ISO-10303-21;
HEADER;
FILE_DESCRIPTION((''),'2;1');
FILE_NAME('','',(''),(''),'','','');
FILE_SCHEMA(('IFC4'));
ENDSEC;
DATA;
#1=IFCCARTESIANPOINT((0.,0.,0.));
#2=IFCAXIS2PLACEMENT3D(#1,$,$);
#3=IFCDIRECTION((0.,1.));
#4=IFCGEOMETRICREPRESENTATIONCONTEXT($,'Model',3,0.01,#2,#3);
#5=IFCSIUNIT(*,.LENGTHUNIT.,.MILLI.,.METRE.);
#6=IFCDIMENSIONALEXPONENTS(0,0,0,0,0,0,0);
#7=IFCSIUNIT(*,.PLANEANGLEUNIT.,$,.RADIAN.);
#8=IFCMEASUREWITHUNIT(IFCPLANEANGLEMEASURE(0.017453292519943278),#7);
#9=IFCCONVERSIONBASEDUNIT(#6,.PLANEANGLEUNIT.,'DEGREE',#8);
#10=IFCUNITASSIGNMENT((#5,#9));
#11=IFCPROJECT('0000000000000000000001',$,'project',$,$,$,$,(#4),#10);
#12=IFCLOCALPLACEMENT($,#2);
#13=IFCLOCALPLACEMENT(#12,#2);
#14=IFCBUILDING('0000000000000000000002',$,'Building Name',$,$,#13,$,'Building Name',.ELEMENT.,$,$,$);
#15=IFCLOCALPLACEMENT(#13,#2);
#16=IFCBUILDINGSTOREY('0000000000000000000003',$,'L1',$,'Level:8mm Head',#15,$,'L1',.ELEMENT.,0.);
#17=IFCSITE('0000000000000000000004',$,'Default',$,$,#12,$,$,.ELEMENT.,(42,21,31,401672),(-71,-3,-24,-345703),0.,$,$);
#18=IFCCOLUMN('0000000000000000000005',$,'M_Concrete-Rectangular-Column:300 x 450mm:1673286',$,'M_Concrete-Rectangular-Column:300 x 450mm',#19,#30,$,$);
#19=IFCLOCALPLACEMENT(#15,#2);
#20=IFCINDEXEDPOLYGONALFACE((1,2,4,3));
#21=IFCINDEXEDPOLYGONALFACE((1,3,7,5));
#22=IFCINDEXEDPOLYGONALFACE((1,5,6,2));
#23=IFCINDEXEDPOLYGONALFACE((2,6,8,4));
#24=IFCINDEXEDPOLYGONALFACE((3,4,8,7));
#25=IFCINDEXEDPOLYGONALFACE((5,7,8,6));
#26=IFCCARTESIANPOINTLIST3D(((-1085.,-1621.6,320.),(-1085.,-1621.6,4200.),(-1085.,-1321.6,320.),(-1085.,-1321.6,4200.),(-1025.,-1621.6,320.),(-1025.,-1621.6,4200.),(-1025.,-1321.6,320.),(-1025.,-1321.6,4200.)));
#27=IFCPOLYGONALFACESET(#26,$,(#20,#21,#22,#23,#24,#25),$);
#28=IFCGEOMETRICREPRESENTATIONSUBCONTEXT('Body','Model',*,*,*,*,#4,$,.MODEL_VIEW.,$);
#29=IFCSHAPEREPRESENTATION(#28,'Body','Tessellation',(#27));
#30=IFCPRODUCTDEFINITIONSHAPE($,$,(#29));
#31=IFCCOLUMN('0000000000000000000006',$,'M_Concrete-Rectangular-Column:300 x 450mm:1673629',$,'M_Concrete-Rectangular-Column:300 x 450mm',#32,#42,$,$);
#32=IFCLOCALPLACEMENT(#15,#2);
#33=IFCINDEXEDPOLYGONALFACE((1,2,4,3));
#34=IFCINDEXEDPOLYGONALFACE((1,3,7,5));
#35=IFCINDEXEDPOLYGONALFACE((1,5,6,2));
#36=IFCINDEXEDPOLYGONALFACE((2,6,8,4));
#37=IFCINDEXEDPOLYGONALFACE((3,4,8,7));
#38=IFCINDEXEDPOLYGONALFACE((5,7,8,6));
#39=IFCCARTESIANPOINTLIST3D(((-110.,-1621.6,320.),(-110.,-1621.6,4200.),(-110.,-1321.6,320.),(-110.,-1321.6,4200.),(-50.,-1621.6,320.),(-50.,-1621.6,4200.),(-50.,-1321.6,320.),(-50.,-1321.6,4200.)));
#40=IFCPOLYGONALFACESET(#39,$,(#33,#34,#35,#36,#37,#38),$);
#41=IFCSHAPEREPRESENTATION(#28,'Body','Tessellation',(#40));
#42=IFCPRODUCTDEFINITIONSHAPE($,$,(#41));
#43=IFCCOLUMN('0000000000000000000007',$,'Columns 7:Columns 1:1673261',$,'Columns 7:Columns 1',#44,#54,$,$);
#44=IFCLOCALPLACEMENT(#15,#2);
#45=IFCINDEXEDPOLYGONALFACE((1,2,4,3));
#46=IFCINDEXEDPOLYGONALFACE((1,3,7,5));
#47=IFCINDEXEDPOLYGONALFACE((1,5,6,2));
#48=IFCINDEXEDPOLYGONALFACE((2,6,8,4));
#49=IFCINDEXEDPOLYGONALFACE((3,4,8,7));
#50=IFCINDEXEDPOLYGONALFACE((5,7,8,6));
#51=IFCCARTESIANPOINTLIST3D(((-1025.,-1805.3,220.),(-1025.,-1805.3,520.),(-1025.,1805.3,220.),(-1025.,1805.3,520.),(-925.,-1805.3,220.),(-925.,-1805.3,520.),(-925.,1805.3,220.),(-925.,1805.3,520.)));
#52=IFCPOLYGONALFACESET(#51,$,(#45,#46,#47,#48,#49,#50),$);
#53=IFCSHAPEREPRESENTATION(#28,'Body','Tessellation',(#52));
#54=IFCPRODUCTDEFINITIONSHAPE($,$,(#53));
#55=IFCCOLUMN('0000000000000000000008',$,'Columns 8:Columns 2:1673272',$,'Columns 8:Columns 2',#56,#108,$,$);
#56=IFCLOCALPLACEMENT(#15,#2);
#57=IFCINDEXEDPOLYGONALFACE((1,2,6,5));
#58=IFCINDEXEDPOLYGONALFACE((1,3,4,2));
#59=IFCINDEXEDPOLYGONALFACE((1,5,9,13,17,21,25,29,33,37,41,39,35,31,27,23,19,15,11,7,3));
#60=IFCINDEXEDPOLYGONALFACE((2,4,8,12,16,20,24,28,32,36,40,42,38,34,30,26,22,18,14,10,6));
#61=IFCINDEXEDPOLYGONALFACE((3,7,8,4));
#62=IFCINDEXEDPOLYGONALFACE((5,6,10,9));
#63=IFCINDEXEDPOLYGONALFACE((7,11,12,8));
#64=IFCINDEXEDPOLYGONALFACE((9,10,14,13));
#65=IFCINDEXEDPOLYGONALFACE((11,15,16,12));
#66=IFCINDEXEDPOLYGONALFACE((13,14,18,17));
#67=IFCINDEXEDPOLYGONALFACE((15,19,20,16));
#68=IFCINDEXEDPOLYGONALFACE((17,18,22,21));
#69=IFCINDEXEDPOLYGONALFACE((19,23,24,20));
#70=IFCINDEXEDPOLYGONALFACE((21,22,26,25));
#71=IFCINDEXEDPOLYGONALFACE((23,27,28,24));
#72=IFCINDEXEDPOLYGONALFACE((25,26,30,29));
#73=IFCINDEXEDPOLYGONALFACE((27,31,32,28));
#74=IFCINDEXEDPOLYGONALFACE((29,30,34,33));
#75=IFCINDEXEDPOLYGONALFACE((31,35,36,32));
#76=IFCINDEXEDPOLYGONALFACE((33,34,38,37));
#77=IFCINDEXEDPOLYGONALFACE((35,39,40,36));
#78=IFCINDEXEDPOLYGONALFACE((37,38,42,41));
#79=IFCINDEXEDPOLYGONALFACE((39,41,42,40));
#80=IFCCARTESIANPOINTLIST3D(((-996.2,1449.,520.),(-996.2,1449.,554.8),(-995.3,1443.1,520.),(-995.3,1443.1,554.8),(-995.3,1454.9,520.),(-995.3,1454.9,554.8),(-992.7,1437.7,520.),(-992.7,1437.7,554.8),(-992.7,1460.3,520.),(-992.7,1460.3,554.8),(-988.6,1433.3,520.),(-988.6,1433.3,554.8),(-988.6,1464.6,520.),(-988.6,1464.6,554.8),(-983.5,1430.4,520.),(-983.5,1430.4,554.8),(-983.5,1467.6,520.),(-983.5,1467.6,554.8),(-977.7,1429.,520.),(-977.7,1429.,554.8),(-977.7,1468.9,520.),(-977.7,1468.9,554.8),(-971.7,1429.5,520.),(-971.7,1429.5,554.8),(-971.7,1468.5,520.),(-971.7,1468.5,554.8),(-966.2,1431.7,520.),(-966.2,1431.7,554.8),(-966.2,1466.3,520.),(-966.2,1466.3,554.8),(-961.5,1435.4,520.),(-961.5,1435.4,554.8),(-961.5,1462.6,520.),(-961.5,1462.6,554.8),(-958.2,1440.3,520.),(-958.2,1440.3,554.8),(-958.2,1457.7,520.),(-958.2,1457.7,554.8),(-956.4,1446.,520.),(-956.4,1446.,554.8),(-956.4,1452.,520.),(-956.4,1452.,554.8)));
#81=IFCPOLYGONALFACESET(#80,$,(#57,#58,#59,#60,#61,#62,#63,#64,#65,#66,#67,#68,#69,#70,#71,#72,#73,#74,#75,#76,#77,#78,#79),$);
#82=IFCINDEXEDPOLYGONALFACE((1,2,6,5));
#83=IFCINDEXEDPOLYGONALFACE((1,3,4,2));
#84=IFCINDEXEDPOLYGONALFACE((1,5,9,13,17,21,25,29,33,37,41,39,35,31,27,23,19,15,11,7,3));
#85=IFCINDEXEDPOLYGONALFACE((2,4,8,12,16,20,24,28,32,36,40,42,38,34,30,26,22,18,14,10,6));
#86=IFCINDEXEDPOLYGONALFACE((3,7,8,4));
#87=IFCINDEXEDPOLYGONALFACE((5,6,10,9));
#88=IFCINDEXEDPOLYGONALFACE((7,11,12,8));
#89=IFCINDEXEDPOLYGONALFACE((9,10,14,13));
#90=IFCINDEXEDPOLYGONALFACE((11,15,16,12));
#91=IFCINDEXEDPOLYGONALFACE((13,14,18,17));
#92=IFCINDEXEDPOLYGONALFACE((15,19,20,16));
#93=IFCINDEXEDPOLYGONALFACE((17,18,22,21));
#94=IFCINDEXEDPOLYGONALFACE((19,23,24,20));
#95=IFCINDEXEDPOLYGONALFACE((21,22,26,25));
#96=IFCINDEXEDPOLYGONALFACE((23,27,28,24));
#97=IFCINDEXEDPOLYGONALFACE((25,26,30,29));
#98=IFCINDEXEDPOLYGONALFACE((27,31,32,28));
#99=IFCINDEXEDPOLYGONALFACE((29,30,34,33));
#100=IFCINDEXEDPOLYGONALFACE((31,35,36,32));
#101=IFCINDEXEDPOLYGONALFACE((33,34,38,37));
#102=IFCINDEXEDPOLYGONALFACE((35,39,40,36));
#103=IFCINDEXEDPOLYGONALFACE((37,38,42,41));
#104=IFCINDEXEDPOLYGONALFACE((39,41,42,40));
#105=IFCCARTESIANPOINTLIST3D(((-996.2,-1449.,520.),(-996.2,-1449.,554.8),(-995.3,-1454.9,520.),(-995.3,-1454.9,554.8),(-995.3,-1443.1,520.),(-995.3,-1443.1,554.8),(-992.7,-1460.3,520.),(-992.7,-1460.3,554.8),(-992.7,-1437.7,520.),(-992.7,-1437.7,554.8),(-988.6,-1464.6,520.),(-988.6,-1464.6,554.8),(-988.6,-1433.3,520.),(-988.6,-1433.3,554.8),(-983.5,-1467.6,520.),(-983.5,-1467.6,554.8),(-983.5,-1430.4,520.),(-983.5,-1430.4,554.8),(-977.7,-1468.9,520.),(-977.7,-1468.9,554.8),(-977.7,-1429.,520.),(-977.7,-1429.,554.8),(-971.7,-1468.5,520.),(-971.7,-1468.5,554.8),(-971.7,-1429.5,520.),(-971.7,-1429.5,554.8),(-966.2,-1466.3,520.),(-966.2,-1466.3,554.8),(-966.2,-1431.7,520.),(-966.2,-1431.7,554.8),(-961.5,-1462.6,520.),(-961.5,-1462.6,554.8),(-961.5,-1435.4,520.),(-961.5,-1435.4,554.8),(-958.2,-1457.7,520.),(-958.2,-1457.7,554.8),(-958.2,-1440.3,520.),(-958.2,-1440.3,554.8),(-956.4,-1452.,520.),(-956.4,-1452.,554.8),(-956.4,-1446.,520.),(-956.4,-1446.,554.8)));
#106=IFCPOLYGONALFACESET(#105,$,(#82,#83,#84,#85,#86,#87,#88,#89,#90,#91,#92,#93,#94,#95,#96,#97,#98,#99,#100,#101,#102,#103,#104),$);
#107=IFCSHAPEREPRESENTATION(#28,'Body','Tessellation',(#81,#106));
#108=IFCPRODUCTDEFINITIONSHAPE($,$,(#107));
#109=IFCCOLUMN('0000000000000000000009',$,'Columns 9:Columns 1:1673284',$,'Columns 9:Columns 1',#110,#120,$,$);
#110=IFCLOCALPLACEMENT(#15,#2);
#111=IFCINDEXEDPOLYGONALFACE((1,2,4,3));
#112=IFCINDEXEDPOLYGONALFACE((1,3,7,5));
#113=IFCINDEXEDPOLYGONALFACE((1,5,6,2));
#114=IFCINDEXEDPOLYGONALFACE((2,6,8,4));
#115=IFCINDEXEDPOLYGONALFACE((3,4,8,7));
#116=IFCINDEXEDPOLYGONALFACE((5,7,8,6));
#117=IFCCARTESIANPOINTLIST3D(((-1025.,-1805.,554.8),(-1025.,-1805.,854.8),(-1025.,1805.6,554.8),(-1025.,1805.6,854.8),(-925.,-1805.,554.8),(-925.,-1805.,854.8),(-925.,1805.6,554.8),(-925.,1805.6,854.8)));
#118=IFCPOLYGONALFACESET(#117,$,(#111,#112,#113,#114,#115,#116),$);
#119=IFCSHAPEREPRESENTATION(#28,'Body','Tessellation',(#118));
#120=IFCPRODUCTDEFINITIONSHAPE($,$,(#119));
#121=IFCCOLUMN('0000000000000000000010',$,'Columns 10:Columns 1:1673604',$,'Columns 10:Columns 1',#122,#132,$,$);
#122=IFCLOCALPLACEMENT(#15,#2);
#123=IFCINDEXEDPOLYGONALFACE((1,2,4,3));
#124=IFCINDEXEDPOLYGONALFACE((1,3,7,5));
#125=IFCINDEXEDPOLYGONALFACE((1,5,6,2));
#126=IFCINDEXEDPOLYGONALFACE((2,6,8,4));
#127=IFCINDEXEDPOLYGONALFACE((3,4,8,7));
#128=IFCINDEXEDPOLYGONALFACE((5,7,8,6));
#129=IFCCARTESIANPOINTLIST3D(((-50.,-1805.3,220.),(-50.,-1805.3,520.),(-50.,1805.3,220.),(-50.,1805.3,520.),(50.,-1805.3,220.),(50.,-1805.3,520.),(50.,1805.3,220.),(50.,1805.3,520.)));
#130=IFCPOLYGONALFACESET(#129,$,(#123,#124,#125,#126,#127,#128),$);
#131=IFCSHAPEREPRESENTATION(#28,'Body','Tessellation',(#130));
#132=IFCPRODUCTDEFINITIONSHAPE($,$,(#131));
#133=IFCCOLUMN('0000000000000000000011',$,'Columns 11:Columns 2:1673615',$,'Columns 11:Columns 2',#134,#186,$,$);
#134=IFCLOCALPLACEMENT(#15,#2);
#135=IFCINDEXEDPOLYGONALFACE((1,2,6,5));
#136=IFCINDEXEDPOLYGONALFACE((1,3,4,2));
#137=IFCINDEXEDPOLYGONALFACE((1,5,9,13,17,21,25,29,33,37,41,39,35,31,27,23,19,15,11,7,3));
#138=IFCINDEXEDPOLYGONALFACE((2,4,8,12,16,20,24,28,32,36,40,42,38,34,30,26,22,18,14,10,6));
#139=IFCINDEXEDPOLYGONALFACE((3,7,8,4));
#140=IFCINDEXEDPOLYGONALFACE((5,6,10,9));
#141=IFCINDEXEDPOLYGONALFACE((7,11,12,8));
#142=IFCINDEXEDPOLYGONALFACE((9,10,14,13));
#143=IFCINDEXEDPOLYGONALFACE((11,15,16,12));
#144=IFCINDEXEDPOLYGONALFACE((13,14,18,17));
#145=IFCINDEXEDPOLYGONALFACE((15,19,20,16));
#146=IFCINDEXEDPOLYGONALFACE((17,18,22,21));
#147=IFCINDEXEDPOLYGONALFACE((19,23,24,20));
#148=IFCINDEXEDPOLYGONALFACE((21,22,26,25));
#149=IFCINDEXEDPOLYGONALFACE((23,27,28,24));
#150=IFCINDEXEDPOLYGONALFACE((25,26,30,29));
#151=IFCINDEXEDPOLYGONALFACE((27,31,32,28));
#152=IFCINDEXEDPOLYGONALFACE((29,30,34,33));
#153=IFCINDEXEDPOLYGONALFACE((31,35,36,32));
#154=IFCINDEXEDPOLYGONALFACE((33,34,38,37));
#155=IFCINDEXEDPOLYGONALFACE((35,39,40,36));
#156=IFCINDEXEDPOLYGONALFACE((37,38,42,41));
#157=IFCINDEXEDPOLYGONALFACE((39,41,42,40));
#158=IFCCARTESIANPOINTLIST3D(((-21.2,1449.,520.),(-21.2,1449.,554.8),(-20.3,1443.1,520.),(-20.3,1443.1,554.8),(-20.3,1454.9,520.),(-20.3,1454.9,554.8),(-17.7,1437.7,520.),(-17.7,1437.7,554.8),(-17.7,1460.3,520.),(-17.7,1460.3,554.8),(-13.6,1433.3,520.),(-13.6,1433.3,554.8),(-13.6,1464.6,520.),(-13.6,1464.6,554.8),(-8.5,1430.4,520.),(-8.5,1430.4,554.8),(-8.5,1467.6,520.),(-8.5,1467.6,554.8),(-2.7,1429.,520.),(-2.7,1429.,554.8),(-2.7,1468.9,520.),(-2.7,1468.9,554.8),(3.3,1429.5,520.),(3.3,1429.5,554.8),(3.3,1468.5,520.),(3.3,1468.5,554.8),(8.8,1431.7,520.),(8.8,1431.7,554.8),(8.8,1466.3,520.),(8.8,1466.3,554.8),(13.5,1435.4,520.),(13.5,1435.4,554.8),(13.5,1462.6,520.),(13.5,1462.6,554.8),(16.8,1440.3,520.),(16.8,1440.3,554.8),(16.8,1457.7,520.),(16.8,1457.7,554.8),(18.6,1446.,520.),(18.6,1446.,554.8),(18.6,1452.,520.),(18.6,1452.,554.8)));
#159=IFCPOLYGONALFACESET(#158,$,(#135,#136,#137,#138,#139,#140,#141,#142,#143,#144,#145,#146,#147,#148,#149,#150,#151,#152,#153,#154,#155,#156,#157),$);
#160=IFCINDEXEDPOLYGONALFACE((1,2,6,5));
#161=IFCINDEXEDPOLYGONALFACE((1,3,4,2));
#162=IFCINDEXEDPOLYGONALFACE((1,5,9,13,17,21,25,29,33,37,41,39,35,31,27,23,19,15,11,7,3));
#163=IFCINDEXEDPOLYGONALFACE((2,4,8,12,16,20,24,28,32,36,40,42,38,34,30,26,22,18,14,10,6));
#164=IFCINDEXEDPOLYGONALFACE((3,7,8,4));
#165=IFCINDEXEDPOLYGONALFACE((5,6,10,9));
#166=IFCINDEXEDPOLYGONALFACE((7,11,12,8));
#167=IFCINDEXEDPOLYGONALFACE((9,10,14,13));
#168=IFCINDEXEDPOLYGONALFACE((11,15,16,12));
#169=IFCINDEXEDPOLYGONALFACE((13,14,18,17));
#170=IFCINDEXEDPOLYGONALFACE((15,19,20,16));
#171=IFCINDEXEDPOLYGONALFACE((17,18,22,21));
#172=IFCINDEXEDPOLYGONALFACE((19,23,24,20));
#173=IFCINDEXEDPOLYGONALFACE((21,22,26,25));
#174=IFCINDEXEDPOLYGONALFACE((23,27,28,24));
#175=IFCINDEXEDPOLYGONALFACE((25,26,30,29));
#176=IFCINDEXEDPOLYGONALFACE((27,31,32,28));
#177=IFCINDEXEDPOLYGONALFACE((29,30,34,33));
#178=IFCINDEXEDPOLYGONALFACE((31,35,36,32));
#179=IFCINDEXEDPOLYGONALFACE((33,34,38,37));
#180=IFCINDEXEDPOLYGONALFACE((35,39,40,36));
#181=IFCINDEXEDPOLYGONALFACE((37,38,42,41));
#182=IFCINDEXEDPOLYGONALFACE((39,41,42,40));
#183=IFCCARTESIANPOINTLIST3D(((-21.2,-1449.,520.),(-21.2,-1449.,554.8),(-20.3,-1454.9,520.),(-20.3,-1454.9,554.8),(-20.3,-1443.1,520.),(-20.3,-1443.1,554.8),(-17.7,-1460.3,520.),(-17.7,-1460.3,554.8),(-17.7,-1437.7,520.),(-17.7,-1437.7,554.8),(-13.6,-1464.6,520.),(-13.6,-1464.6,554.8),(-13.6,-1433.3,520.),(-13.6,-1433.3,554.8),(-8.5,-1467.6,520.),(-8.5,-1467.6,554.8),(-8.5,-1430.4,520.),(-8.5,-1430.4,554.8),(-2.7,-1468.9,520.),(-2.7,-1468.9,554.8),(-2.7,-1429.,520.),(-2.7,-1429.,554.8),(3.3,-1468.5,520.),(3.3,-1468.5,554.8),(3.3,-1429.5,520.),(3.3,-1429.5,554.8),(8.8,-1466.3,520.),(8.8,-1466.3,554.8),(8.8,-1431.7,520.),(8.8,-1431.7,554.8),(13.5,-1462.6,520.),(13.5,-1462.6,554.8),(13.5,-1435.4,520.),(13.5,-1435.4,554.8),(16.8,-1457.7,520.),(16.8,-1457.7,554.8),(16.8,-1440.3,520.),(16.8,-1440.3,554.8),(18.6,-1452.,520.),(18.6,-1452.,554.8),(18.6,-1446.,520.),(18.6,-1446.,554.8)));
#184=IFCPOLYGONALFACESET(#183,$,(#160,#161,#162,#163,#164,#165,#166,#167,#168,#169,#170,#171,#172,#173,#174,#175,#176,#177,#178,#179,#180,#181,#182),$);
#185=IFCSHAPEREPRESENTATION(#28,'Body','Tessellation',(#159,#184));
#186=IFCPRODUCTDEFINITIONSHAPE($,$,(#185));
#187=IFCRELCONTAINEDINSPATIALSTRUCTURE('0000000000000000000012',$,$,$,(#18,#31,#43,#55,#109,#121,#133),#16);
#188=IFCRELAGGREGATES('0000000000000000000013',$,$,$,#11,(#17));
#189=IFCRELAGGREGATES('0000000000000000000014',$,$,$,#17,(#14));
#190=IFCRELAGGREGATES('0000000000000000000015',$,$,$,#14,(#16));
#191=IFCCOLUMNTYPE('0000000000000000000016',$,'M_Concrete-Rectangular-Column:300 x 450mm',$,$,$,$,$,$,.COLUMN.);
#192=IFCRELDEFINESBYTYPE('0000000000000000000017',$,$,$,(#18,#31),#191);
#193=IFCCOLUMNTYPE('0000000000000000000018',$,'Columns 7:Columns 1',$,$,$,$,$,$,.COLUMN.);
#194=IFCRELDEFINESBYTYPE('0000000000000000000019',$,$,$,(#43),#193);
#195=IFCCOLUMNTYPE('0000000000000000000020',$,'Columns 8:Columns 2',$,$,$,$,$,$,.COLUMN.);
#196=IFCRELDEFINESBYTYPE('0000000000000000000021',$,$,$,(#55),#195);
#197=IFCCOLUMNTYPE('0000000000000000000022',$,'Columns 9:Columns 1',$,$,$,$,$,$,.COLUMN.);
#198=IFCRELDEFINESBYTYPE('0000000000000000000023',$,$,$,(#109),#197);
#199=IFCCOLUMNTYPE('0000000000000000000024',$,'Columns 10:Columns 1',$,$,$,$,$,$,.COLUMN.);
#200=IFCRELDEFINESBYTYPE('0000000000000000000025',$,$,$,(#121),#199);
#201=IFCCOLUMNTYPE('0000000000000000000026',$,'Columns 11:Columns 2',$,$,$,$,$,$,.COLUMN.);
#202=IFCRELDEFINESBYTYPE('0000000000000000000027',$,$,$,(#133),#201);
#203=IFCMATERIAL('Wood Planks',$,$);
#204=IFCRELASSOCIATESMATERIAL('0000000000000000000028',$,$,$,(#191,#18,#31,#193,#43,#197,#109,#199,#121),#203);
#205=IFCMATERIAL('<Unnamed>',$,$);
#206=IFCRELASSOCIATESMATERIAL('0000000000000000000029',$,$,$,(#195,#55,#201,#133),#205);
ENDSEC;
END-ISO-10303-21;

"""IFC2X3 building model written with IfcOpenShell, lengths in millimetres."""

from ifc_helpers import new_model, entity, si_unit, converted_unit, direction, frame, frame_2d, origin, origin_2d_with_axis, place, context, subcontext, project, spatial, rectangle, circle, extrude, source, transform, mapped, material, type_object, type_shapes, element, save


model = new_model("IFC2X3")

# Units and contexts
model_context = context("Model", 3, precision=0.01, world=origin(), true_north=direction((0.0, 1.0)))
body_context = subcontext(model_context, "Body", "Model", "MODEL_VIEW")
ifc_project = project(units=[si_unit("LENGTHUNIT", "METRE", prefix="MILLI"), converted_unit("PLANEANGLEUNIT", "DEGREE", entity("IfcPlaneAngleMeasure", 0.017453292519943278), si_unit("PLANEANGLEUNIT", "RADIAN"), dimensions=[0, 0, 0, 0, 0, 0, 0])], contexts=[model_context])

# Site, building, storey
site_placement = place(None, origin())
site = spatial("IfcSite", under=ifc_project, at=site_placement, Name="Default", CompositionType="ELEMENT", RefLatitude=(42, 21, 31, 401672), RefLongitude=(-71, -3, -24, -345703), RefElevation=0.0)
building_placement = place(site_placement, origin())
building = spatial("IfcBuilding", under=site, at=building_placement, Name="Building Name", LongName="Building Name", CompositionType="ELEMENT")
storey_placement = place(building_placement, origin())
storey = spatial("IfcBuildingStorey", under=building, at=storey_placement, Name="L1", ObjectType="Level:8mm Head", LongName="L1", CompositionType="ELEMENT", Elevation=0.0)

# Columns
ifc_material_1 = material(Name="<Unnamed>")
ifc_material_2 = material(Name="Wood Planks")
column_type_1 = type_object("IfcColumnType", Name="M_Concrete-Rectangular-Column:300 x 450mm", PredefinedType="COLUMN", material=ifc_material_2)
shared_shape_1 = source(origin(), body_context, "Body", "SweptSolid", [
    extrude(rectangle(XDim=60.0, YDim=300.0, at=origin_2d_with_axis()), frame((0.0, 0.0, 320.0), z_axis=(0.0, 0.0, 1.0), x_axis=(-1.0, 0.0, 0.0)), (0.0, 0.0, 1.0), 3880.0),
])
type_shapes(column_type_1, [shared_shape_1])
for number, where, name in (
    (1, (-1055.0, -1471.6, 0.0), "M_Concrete-Rectangular-Column:300 x 450mm:1673286"),
    (2, (-80.0, -1471.6, 0.0), "M_Concrete-Rectangular-Column:300 x 450mm:1673629"),
):
    element("IfcColumn", number, at=place(storey_placement, frame(where)), inside=storey, type_object=column_type_1, material=ifc_material_2, Name=name, ObjectType="M_Concrete-Rectangular-Column:300 x 450mm", context=body_context, shape_type="MappedRepresentation", body=[
        mapped(shared_shape_1, transform((0.0, 0.0, 0.0), scale=1.0)),
    ])
column_type_2 = type_object("IfcColumnType", Name="Columns 7:Columns 1", PredefinedType="COLUMN", material=ifc_material_2)
shared_shape_2 = source(origin(), body_context, "Body", "SweptSolid", [
    extrude(rectangle(XDim=3610.6, YDim=100.0, at=frame_2d((0.0, 0.0), x_axis=(1.0, 0.0))), frame((-975.0, 0.0, 220.0), z_axis=(0.0, 0.0, 1.0), x_axis=(0.0, -1.0, 0.0)), (0.0, 0.0, 1.0), 300.0),
])
type_shapes(column_type_2, [shared_shape_2])
column_1_placement = place(storey_placement, origin())
element("IfcColumn", 3, at=column_1_placement, inside=storey, type_object=column_type_2, material=ifc_material_2, Name="Columns 7:Columns 1:1673261", ObjectType="Columns 7:Columns 1", context=body_context, shape_type="MappedRepresentation", body=[
    mapped(shared_shape_2, transform((0.0, 0.0, 0.0), scale=1.0)),
])
column_type_3 = type_object("IfcColumnType", Name="Columns 8:Columns 2", PredefinedType="COLUMN", material=ifc_material_1)
shared_shape_3 = source(origin(), body_context, "Body", "SweptSolid", [
    extrude(circle(Radius=20.0, at=origin_2d_with_axis()), frame((-976.2, 1449.0, 520.0), z_axis=(0.0, 0.0, 1.0), x_axis=(-1.0, 0.0, 0.0)), (0.0, 0.0, 1.0), 34.8),
    extrude(circle(Radius=20.0, at=frame_2d((0.0, 0.0), x_axis=(1.0, 0.0))), frame((-976.2, -1449.0, 520.0), z_axis=(0.0, 0.0, 1.0), x_axis=(-1.0, 0.0, 0.0)), (0.0, 0.0, 1.0), 34.8),
])
type_shapes(column_type_3, [shared_shape_3])
column_2_placement = place(storey_placement, origin())
element("IfcColumn", 4, at=column_2_placement, inside=storey, type_object=column_type_3, material=ifc_material_1, Name="Columns 8:Columns 2:1673272", ObjectType="Columns 8:Columns 2", context=body_context, shape_type="MappedRepresentation", body=[
    mapped(shared_shape_3, transform((0.0, 0.0, 0.0), scale=1.0)),
])
column_type_4 = type_object("IfcColumnType", Name="Columns 9:Columns 1", PredefinedType="COLUMN", material=ifc_material_2)
shared_shape_4 = source(origin(), body_context, "Body", "SweptSolid", [
    extrude(rectangle(XDim=3610.6, YDim=100.0, at=frame_2d((0.0, 0.0), x_axis=(1.0, 0.0))), frame((-975.0, 0.3, 554.8), z_axis=(0.0, 0.0, 1.0), x_axis=(0.0, -1.0, 0.0)), (0.0, 0.0, 1.0), 300.0),
])
type_shapes(column_type_4, [shared_shape_4])
column_3_placement = place(storey_placement, origin())
element("IfcColumn", 5, at=column_3_placement, inside=storey, type_object=column_type_4, material=ifc_material_2, Name="Columns 9:Columns 1:1673284", ObjectType="Columns 9:Columns 1", context=body_context, shape_type="MappedRepresentation", body=[
    mapped(shared_shape_4, transform((0.0, 0.0, 0.0), scale=1.0)),
])
column_type_5 = type_object("IfcColumnType", Name="Columns 10:Columns 1", PredefinedType="COLUMN", material=ifc_material_2)
shared_shape_5 = source(origin(), body_context, "Body", "SweptSolid", [
    extrude(rectangle(XDim=3610.6, YDim=100.0, at=origin_2d_with_axis()), frame((0.0, 0.0, 220.0), z_axis=(0.0, 0.0, 1.0), x_axis=(0.0, -1.0, 0.0)), (0.0, 0.0, 1.0), 300.0),
])
type_shapes(column_type_5, [shared_shape_5])
column_4_placement = place(storey_placement, origin())
element("IfcColumn", 6, at=column_4_placement, inside=storey, type_object=column_type_5, material=ifc_material_2, Name="Columns 10:Columns 1:1673604", ObjectType="Columns 10:Columns 1", context=body_context, shape_type="MappedRepresentation", body=[
    mapped(shared_shape_5, transform((0.0, 0.0, 0.0), scale=1.0)),
])
column_type_6 = type_object("IfcColumnType", Name="Columns 11:Columns 2", PredefinedType="COLUMN", material=ifc_material_1)
shared_shape_6 = source(origin(), body_context, "Body", "SweptSolid", [
    extrude(circle(Radius=20.0, at=origin_2d_with_axis()), frame((-1.2, 1449.0, 520.0), z_axis=(0.0, 0.0, 1.0), x_axis=(-1.0, 0.0, 0.0)), (0.0, 0.0, 1.0), 34.8),
    extrude(circle(Radius=20.0, at=frame_2d((0.0, 0.0), x_axis=(1.0, 0.0))), frame((-1.2, -1449.0, 520.0), z_axis=(0.0, 0.0, 1.0), x_axis=(-1.0, 0.0, 0.0)), (0.0, 0.0, 1.0), 34.8),
])
type_shapes(column_type_6, [shared_shape_6])
column_5_placement = place(storey_placement, origin())
element("IfcColumn", 7, at=column_5_placement, inside=storey, type_object=column_type_6, material=ifc_material_1, Name="Columns 11:Columns 2:1673615", ObjectType="Columns 11:Columns 2", context=body_context, shape_type="MappedRepresentation", body=[
    mapped(shared_shape_6, transform((0.0, 0.0, 0.0), scale=1.0)),
])

save(model, "model.ifc")
